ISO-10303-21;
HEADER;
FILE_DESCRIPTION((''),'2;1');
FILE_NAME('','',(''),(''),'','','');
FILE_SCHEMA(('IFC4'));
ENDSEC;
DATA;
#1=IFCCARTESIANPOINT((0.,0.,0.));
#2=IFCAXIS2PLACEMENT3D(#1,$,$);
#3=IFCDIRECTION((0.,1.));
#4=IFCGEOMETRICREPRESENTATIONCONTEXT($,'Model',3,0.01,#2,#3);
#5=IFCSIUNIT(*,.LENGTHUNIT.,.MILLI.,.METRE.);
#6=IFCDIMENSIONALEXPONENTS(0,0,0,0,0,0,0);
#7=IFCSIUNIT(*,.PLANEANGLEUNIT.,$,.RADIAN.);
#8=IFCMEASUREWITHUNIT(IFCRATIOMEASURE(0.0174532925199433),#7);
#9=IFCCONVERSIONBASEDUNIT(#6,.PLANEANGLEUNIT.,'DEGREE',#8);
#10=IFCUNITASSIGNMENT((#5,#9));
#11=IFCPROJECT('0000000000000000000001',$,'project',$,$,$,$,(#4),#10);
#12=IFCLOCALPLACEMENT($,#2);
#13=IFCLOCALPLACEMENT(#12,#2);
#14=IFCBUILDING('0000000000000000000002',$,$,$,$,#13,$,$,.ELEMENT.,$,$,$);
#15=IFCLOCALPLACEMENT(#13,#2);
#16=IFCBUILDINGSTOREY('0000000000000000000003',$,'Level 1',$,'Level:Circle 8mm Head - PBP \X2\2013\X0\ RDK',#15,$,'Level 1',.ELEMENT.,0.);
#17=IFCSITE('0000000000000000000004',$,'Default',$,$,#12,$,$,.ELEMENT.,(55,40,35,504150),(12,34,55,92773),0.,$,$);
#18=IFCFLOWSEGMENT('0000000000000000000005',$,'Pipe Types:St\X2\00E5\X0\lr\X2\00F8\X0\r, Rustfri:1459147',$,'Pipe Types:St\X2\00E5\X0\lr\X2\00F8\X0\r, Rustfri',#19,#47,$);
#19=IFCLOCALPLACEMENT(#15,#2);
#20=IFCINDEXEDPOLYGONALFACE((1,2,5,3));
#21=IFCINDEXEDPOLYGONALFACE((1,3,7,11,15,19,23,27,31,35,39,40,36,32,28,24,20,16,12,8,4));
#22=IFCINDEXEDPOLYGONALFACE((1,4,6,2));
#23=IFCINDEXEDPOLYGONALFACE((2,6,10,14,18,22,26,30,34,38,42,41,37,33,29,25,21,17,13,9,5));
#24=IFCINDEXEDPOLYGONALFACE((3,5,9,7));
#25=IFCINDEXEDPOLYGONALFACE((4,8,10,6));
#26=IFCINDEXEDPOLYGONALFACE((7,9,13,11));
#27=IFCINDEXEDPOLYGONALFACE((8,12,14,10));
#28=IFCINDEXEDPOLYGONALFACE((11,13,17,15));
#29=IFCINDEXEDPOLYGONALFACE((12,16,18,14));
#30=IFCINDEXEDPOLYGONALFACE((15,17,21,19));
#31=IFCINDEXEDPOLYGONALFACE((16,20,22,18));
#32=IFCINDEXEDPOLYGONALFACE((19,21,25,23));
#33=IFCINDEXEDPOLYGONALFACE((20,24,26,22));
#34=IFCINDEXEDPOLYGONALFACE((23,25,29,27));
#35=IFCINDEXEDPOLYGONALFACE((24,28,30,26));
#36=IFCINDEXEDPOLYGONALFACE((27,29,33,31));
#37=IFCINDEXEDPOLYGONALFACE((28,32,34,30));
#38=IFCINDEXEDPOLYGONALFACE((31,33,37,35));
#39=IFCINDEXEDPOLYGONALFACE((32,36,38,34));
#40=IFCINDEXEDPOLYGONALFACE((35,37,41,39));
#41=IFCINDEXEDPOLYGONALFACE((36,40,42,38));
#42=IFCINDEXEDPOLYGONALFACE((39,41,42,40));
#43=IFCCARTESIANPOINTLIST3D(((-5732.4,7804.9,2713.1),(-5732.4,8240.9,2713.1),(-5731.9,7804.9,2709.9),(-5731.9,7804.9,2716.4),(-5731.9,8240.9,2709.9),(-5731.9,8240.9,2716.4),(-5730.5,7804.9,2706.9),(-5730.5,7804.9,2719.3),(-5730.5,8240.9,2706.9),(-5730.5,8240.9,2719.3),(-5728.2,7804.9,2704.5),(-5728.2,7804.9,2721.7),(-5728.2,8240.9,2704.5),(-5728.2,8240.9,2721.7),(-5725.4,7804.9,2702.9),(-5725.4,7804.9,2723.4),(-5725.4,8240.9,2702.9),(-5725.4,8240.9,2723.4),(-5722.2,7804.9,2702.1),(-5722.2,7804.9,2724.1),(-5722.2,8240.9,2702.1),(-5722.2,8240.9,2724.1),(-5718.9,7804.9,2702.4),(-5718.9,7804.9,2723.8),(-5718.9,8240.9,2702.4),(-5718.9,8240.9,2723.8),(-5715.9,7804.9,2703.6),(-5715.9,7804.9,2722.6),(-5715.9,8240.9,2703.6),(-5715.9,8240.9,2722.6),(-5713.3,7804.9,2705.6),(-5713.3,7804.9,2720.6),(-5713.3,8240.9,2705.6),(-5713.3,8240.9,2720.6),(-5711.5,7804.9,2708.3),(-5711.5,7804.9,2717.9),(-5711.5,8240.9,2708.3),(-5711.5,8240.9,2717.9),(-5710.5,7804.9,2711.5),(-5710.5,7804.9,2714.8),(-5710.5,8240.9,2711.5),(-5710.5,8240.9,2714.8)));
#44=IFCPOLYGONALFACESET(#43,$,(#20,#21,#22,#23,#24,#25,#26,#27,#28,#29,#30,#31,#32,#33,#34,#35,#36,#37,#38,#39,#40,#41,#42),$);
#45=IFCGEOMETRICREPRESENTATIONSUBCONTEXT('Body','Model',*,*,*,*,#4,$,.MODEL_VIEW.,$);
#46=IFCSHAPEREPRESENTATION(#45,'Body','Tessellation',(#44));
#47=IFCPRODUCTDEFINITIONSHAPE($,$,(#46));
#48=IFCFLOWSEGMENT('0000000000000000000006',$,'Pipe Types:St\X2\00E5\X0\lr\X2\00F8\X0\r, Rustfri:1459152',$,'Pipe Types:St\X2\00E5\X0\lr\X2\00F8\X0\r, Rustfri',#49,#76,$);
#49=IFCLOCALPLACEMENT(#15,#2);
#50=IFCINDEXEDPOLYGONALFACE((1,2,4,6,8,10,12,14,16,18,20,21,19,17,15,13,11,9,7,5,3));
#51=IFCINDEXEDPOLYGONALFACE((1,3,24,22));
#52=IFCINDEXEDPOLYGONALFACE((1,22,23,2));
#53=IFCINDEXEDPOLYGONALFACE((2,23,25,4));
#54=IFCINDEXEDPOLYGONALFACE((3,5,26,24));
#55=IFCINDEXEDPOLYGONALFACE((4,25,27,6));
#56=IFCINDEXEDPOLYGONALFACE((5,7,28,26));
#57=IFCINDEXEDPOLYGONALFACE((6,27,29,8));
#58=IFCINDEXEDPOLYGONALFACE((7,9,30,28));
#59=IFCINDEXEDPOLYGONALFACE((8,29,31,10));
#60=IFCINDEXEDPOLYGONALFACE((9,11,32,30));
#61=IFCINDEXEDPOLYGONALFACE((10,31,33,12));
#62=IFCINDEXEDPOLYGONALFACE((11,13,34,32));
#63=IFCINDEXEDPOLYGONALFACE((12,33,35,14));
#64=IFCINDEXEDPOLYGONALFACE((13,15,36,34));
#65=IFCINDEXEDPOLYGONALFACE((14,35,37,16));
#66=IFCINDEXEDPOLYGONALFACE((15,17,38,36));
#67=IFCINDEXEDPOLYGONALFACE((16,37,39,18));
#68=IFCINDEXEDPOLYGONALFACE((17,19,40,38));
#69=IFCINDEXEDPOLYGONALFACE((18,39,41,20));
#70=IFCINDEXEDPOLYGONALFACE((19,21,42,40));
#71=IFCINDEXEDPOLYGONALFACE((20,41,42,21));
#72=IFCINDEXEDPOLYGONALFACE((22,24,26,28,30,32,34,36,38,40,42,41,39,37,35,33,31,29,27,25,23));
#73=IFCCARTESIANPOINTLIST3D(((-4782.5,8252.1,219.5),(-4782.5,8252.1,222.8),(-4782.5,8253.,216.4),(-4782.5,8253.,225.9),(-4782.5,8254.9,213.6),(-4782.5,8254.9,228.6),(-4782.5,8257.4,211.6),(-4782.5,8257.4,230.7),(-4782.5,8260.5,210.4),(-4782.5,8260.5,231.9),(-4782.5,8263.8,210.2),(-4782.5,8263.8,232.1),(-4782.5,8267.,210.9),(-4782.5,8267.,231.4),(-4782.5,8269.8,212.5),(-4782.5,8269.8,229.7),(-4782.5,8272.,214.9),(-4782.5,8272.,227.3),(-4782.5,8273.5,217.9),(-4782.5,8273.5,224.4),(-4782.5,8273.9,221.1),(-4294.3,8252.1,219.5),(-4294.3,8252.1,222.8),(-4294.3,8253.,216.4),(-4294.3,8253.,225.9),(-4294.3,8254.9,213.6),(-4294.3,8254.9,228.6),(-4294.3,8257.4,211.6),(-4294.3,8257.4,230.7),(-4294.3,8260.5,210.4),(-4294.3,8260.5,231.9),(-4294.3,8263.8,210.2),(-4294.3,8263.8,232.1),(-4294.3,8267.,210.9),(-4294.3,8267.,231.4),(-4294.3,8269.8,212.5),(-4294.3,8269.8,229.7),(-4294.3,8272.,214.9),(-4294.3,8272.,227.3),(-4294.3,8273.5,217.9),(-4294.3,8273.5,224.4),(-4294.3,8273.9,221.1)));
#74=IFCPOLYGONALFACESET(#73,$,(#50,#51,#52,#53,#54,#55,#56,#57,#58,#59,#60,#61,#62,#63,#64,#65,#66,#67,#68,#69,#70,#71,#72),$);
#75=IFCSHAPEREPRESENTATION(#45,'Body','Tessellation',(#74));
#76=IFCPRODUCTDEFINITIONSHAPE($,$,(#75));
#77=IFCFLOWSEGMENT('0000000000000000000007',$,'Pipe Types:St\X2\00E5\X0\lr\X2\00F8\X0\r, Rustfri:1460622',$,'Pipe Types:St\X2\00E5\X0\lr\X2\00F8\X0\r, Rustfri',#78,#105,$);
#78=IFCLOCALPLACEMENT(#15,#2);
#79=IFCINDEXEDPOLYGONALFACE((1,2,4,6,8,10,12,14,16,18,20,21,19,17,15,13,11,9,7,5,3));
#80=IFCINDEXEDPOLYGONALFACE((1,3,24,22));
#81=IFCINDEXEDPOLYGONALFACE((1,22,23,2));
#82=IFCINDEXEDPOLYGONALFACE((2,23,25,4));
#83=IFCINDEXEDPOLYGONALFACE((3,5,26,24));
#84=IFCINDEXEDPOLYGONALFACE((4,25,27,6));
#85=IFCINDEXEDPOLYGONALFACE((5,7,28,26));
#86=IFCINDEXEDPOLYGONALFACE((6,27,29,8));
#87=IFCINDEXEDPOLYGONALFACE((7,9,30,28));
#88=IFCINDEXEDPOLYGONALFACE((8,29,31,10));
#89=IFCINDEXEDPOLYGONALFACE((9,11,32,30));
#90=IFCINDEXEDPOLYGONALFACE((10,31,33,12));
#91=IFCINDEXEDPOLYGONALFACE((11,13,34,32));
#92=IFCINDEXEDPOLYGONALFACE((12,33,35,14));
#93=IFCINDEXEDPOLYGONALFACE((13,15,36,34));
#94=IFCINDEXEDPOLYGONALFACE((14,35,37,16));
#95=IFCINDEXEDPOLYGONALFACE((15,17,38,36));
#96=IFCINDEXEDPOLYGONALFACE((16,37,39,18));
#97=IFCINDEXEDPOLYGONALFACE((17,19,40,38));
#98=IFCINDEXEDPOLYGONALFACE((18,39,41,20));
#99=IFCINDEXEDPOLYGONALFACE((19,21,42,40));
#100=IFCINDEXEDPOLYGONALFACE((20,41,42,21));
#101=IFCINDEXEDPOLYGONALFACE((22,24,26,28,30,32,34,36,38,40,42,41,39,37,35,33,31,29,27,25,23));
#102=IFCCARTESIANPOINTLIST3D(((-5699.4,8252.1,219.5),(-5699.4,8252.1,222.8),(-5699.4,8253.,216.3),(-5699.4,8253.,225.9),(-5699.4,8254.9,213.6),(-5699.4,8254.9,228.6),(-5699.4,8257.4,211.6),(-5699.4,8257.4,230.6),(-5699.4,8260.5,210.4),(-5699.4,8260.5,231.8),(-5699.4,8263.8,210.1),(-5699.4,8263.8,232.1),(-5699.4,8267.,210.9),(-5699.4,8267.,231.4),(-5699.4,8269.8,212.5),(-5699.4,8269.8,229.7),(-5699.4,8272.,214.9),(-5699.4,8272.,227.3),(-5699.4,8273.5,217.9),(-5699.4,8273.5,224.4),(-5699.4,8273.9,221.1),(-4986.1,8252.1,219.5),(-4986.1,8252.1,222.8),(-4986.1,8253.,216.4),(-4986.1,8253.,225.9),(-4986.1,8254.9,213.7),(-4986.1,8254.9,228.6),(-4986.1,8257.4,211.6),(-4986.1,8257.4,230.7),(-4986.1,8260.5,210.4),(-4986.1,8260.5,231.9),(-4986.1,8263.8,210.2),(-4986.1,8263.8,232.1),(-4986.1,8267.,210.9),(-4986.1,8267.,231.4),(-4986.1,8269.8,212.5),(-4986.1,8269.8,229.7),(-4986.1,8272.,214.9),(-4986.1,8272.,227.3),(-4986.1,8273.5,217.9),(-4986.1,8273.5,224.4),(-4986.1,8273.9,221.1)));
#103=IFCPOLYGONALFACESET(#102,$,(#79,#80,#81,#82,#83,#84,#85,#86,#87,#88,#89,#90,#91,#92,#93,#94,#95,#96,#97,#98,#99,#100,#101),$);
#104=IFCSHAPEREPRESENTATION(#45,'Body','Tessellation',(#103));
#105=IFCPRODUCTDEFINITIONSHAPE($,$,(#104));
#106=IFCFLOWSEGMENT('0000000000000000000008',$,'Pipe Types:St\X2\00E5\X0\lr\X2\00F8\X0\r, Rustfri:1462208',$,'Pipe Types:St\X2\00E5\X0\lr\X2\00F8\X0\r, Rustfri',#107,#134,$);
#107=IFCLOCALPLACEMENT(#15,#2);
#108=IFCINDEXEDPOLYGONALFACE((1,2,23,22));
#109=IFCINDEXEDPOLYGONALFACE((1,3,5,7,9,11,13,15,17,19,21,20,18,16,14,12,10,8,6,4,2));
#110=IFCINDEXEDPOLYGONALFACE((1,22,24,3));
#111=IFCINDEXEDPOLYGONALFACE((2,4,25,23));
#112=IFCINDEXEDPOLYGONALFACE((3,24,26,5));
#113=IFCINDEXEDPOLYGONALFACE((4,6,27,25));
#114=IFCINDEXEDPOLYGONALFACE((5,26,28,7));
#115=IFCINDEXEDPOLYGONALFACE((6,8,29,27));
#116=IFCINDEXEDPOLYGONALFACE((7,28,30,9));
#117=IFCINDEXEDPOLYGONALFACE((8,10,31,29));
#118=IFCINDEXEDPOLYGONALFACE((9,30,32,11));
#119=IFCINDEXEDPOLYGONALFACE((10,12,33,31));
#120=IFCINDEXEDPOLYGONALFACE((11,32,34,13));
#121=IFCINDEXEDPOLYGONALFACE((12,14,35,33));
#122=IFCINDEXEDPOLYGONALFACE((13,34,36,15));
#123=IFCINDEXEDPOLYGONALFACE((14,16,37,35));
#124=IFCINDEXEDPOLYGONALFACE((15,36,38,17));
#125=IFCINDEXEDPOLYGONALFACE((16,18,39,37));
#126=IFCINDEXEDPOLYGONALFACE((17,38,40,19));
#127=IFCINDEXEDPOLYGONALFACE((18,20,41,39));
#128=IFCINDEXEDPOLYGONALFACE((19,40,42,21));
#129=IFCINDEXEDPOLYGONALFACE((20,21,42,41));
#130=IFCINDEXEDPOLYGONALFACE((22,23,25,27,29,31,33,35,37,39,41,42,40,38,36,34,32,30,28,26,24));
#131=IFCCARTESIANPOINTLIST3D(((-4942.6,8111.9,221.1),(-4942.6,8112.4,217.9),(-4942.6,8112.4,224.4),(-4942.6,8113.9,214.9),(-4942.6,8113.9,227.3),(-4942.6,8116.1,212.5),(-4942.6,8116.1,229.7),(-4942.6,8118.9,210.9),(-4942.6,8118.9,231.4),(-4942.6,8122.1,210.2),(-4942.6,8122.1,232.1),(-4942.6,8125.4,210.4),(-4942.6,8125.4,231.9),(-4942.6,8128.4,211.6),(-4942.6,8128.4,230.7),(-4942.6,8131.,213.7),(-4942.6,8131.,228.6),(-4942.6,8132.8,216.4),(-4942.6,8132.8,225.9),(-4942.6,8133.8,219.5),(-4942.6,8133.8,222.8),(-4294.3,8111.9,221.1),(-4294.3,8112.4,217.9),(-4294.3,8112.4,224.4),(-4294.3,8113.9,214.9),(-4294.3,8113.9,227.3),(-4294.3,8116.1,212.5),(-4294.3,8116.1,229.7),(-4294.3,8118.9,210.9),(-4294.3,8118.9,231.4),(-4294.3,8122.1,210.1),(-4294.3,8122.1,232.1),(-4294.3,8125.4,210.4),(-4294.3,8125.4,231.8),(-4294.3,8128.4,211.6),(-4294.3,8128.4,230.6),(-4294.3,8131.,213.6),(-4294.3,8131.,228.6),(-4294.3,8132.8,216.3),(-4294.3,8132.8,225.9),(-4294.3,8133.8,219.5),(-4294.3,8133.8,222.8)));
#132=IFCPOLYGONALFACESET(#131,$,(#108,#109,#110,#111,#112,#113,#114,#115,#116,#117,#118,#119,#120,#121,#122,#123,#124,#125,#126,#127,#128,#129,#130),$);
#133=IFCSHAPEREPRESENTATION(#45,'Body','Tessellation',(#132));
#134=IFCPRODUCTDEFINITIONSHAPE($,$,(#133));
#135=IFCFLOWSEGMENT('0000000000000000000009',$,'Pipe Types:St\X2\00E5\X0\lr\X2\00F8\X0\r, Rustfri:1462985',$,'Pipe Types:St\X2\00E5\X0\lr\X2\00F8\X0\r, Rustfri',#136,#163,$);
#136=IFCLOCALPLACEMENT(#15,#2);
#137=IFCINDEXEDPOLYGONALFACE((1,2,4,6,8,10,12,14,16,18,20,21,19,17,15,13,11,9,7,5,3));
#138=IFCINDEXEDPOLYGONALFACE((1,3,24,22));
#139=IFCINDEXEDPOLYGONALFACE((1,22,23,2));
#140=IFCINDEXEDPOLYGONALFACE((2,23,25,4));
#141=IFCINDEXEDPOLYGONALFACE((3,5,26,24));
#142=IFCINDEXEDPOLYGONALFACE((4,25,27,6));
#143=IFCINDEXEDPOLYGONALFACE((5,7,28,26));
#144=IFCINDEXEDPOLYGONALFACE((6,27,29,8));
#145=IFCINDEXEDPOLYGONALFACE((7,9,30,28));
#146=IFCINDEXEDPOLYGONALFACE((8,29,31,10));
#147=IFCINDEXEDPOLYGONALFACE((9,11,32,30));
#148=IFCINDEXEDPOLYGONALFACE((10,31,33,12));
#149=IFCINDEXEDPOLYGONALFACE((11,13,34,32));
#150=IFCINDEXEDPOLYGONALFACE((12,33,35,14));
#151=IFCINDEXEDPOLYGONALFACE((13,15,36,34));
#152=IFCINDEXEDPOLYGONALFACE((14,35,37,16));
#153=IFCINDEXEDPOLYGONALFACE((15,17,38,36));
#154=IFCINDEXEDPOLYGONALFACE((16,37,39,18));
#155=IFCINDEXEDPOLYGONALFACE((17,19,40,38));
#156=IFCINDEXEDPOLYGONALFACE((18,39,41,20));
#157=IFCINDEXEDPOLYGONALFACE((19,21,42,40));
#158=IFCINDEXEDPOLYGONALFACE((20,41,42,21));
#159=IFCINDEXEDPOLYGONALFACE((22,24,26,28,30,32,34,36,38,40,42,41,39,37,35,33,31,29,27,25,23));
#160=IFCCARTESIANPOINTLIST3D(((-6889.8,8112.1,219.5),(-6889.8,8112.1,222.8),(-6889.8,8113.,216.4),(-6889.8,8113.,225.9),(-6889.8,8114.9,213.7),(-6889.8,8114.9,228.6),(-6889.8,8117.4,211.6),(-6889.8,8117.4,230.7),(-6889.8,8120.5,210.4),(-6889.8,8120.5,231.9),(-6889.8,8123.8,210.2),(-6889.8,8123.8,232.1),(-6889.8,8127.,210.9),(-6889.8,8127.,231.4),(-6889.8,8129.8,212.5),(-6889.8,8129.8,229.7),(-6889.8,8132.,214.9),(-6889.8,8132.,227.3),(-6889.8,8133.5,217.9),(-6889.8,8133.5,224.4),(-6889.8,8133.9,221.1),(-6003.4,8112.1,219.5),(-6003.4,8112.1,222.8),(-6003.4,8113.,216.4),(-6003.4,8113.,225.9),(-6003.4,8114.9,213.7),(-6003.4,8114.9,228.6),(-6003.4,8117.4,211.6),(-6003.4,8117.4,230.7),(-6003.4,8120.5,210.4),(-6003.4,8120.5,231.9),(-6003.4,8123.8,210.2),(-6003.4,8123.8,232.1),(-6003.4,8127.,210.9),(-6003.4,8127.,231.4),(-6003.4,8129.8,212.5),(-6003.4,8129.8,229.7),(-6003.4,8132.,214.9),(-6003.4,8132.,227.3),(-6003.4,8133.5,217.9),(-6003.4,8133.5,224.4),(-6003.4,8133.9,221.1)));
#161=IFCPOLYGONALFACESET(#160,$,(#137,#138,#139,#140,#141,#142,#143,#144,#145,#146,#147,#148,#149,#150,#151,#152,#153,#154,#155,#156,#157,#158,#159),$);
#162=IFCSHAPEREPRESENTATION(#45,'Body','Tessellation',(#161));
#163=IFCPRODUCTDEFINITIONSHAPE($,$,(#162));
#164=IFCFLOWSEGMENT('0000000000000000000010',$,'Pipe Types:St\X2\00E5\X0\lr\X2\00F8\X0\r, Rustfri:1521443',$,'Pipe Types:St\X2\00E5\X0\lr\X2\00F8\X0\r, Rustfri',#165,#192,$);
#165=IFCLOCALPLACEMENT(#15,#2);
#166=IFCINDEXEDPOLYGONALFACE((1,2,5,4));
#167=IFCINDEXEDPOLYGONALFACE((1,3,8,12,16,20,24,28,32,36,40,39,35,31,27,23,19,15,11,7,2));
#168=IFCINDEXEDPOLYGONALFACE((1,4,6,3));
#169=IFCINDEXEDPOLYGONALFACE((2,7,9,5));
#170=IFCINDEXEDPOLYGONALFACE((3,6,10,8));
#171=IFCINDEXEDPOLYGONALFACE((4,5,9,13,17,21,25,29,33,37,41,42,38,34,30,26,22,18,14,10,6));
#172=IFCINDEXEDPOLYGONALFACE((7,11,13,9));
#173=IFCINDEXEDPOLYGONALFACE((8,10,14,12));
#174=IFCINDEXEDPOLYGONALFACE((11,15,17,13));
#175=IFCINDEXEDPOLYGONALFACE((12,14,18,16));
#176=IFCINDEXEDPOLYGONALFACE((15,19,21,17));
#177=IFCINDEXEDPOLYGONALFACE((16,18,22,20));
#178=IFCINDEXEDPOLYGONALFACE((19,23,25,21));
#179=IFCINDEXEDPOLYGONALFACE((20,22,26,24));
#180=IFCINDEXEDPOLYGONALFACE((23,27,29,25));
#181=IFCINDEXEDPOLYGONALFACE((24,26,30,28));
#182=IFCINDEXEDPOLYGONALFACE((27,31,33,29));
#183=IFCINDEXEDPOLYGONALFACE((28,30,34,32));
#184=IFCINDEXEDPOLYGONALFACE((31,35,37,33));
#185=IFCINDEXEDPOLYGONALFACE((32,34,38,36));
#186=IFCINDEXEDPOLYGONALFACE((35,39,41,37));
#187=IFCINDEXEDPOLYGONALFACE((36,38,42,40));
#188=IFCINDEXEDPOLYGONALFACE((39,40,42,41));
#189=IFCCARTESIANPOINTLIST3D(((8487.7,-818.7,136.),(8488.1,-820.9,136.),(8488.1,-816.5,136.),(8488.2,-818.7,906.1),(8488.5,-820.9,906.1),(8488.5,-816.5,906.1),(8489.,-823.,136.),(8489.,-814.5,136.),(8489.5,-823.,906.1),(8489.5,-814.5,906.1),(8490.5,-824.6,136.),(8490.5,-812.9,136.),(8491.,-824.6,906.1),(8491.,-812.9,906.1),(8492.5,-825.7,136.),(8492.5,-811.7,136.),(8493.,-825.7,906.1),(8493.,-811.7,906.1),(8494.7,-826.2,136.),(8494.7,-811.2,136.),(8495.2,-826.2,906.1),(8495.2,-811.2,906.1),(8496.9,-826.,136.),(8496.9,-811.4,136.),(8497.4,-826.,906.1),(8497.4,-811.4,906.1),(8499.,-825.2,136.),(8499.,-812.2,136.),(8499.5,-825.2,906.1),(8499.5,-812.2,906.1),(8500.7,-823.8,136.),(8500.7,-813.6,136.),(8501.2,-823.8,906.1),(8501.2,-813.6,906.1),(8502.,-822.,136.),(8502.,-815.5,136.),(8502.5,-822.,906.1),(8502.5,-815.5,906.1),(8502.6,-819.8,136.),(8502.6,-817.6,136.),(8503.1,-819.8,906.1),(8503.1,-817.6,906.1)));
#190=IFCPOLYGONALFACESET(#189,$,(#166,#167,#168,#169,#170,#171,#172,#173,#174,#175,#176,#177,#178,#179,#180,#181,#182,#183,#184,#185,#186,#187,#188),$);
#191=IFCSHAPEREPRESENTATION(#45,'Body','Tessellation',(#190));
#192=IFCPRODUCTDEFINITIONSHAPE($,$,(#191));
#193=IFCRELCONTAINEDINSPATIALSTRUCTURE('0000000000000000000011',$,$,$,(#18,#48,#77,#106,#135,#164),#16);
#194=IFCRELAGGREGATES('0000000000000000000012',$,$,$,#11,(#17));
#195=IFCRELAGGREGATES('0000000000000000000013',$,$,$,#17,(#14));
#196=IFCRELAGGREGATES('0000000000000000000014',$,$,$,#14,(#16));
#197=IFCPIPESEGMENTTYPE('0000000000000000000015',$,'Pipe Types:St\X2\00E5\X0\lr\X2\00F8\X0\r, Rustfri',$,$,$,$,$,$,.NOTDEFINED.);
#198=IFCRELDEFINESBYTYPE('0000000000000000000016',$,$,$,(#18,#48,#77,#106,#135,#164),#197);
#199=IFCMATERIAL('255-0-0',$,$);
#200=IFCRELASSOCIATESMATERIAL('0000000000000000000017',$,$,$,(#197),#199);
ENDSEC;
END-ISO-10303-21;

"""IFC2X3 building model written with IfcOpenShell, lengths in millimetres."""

from ifc_helpers import new_model, entity, si_unit, converted_unit, direction, frame, frame_2d, origin, origin_2d_with_axis, place, context, subcontext, project, spatial, circle, extrude, material, type_object, element, save


model = new_model("IFC2X3")

# Units and contexts
model_context = context("Model", 3, precision=0.01, world=origin(), true_north=direction((0.0, 1.0)))
body_context = subcontext(model_context, "Body", "Model", "MODEL_VIEW")
ifc_project = project(units=[si_unit("LENGTHUNIT", "METRE", prefix="MILLI"), converted_unit("PLANEANGLEUNIT", "DEGREE", entity("IfcRatioMeasure", 0.0174532925199433), si_unit("PLANEANGLEUNIT", "RADIAN"), dimensions=[0, 0, 0, 0, 0, 0, 0])], contexts=[model_context])

# Site, building, storey
site_placement = place(None, origin())
site = spatial("IfcSite", under=ifc_project, at=site_placement, Name="Default", CompositionType="ELEMENT", RefLatitude=(55, 40, 35, 504150), RefLongitude=(12, 34, 55, 92773), RefElevation=0.0)
building_placement = place(site_placement, origin())
building = spatial("IfcBuilding", under=site, at=building_placement, CompositionType="ELEMENT")
storey_placement = place(building_placement, origin())
storey = spatial("IfcBuildingStorey", under=building, at=storey_placement, Name="Level 1", ObjectType="Level:Circle 8mm Head - PBP – RDK", LongName="Level 1", CompositionType="ELEMENT", Elevation=0.0)

# Flow segments
ifc_material = material(Name="255-0-0")
pipe_segment_type = type_object("IfcPipeSegmentType", Name="Pipe Types:Stålrør, Rustfri", PredefinedType="NOTDEFINED", material=ifc_material)
flow_segment_1_placement = place(storey_placement, origin())
element("IfcFlowSegment", 1, at=flow_segment_1_placement, inside=storey, type_object=pipe_segment_type, Name="Pipe Types:Stålrør, Rustfri:1459147", ObjectType="Pipe Types:Stålrør, Rustfri", context=body_context, shape_type="SweptSolid", body=[
    extrude(circle(Radius=11.0, at=frame_2d((0.0, 0.0), x_axis=(1.0, 0.0))), frame((-5721.4, 7804.9, 2713.1), z_axis=(0.0, 1.0, 0.0), x_axis=(-1.0, 0.0, 0.0)), (0.0, 0.0, 1.0), 436.0),
])
flow_segment_2_placement = place(storey_placement, origin())
element("IfcFlowSegment", 2, at=flow_segment_2_placement, inside=storey, type_object=pipe_segment_type, Name="Pipe Types:Stålrør, Rustfri:1459152", ObjectType="Pipe Types:Stålrør, Rustfri", context=body_context, shape_type="SweptSolid", body=[
    extrude(circle(Radius=11.0, at=frame_2d((0.0, 0.0), x_axis=(1.0, 0.0))), frame((-4782.5, 8262.9, 221.1), z_axis=(1.0, 0.0, 0.0), x_axis=(0.0, 1.0, 0.0)), (0.0, 0.0, 1.0), 488.2),
])
flow_segment_3_placement = place(storey_placement, origin())
element("IfcFlowSegment", 3, at=flow_segment_3_placement, inside=storey, type_object=pipe_segment_type, Name="Pipe Types:Stålrør, Rustfri:1460622", ObjectType="Pipe Types:Stålrør, Rustfri", context=body_context, shape_type="SweptSolid", body=[
    extrude(circle(Radius=11.0, at=frame_2d((0.0, 0.0), x_axis=(1.0, 0.0))), frame((-5699.4, 8262.9, 221.1), z_axis=(1.0, 0.0, 0.000022), x_axis=(0.0, 1.0, 0.0)), (0.0, 0.0, 1.0), 713.3),
])
flow_segment_4_placement = place(storey_placement, origin())
element("IfcFlowSegment", 4, at=flow_segment_4_placement, inside=storey, type_object=pipe_segment_type, Name="Pipe Types:Stålrør, Rustfri:1462208", ObjectType="Pipe Types:Stålrør, Rustfri", context=body_context, shape_type="SweptSolid", body=[
    extrude(circle(Radius=11.0, at=frame_2d((0.0, 0.0), x_axis=(1.0, 0.0))), frame((-4294.3, 8122.9, 221.1), z_axis=(-1.0, 0.0, 0.00003), x_axis=(0.0, -1.0, 0.0)), (0.0, 0.0, 1.0), 648.3),
])
flow_segment_5_placement = place(storey_placement, origin())
element("IfcFlowSegment", 5, at=flow_segment_5_placement, inside=storey, type_object=pipe_segment_type, Name="Pipe Types:Stålrør, Rustfri:1462985", ObjectType="Pipe Types:Stålrør, Rustfri", context=body_context, shape_type="SweptSolid", body=[
    extrude(circle(Radius=11.0, at=origin_2d_with_axis()), frame((-6889.8, 8122.9, 221.1), z_axis=(1.0, 0.0, 0.0), x_axis=(0.0, 1.0, 0.0)), (0.0, 0.0, 1.0), 886.4),
])
flow_segment_6_placement = place(storey_placement, origin())
element("IfcFlowSegment", 6, at=flow_segment_6_placement, inside=storey, type_object=pipe_segment_type, Name="Pipe Types:Stålrør, Rustfri:1521443", ObjectType="Pipe Types:Stålrør, Rustfri", context=body_context, shape_type="SweptSolid", body=[
    extrude(circle(Radius=7.5, at=origin_2d_with_axis()), frame((8495.2, -818.7, 136.0), z_axis=(0.000636, 0.0, 1.0), x_axis=(-1.0, 0.0, 0.000636)), (0.0, 0.0, 1.0), 770.1),
])

save(model, "model.ifc")
